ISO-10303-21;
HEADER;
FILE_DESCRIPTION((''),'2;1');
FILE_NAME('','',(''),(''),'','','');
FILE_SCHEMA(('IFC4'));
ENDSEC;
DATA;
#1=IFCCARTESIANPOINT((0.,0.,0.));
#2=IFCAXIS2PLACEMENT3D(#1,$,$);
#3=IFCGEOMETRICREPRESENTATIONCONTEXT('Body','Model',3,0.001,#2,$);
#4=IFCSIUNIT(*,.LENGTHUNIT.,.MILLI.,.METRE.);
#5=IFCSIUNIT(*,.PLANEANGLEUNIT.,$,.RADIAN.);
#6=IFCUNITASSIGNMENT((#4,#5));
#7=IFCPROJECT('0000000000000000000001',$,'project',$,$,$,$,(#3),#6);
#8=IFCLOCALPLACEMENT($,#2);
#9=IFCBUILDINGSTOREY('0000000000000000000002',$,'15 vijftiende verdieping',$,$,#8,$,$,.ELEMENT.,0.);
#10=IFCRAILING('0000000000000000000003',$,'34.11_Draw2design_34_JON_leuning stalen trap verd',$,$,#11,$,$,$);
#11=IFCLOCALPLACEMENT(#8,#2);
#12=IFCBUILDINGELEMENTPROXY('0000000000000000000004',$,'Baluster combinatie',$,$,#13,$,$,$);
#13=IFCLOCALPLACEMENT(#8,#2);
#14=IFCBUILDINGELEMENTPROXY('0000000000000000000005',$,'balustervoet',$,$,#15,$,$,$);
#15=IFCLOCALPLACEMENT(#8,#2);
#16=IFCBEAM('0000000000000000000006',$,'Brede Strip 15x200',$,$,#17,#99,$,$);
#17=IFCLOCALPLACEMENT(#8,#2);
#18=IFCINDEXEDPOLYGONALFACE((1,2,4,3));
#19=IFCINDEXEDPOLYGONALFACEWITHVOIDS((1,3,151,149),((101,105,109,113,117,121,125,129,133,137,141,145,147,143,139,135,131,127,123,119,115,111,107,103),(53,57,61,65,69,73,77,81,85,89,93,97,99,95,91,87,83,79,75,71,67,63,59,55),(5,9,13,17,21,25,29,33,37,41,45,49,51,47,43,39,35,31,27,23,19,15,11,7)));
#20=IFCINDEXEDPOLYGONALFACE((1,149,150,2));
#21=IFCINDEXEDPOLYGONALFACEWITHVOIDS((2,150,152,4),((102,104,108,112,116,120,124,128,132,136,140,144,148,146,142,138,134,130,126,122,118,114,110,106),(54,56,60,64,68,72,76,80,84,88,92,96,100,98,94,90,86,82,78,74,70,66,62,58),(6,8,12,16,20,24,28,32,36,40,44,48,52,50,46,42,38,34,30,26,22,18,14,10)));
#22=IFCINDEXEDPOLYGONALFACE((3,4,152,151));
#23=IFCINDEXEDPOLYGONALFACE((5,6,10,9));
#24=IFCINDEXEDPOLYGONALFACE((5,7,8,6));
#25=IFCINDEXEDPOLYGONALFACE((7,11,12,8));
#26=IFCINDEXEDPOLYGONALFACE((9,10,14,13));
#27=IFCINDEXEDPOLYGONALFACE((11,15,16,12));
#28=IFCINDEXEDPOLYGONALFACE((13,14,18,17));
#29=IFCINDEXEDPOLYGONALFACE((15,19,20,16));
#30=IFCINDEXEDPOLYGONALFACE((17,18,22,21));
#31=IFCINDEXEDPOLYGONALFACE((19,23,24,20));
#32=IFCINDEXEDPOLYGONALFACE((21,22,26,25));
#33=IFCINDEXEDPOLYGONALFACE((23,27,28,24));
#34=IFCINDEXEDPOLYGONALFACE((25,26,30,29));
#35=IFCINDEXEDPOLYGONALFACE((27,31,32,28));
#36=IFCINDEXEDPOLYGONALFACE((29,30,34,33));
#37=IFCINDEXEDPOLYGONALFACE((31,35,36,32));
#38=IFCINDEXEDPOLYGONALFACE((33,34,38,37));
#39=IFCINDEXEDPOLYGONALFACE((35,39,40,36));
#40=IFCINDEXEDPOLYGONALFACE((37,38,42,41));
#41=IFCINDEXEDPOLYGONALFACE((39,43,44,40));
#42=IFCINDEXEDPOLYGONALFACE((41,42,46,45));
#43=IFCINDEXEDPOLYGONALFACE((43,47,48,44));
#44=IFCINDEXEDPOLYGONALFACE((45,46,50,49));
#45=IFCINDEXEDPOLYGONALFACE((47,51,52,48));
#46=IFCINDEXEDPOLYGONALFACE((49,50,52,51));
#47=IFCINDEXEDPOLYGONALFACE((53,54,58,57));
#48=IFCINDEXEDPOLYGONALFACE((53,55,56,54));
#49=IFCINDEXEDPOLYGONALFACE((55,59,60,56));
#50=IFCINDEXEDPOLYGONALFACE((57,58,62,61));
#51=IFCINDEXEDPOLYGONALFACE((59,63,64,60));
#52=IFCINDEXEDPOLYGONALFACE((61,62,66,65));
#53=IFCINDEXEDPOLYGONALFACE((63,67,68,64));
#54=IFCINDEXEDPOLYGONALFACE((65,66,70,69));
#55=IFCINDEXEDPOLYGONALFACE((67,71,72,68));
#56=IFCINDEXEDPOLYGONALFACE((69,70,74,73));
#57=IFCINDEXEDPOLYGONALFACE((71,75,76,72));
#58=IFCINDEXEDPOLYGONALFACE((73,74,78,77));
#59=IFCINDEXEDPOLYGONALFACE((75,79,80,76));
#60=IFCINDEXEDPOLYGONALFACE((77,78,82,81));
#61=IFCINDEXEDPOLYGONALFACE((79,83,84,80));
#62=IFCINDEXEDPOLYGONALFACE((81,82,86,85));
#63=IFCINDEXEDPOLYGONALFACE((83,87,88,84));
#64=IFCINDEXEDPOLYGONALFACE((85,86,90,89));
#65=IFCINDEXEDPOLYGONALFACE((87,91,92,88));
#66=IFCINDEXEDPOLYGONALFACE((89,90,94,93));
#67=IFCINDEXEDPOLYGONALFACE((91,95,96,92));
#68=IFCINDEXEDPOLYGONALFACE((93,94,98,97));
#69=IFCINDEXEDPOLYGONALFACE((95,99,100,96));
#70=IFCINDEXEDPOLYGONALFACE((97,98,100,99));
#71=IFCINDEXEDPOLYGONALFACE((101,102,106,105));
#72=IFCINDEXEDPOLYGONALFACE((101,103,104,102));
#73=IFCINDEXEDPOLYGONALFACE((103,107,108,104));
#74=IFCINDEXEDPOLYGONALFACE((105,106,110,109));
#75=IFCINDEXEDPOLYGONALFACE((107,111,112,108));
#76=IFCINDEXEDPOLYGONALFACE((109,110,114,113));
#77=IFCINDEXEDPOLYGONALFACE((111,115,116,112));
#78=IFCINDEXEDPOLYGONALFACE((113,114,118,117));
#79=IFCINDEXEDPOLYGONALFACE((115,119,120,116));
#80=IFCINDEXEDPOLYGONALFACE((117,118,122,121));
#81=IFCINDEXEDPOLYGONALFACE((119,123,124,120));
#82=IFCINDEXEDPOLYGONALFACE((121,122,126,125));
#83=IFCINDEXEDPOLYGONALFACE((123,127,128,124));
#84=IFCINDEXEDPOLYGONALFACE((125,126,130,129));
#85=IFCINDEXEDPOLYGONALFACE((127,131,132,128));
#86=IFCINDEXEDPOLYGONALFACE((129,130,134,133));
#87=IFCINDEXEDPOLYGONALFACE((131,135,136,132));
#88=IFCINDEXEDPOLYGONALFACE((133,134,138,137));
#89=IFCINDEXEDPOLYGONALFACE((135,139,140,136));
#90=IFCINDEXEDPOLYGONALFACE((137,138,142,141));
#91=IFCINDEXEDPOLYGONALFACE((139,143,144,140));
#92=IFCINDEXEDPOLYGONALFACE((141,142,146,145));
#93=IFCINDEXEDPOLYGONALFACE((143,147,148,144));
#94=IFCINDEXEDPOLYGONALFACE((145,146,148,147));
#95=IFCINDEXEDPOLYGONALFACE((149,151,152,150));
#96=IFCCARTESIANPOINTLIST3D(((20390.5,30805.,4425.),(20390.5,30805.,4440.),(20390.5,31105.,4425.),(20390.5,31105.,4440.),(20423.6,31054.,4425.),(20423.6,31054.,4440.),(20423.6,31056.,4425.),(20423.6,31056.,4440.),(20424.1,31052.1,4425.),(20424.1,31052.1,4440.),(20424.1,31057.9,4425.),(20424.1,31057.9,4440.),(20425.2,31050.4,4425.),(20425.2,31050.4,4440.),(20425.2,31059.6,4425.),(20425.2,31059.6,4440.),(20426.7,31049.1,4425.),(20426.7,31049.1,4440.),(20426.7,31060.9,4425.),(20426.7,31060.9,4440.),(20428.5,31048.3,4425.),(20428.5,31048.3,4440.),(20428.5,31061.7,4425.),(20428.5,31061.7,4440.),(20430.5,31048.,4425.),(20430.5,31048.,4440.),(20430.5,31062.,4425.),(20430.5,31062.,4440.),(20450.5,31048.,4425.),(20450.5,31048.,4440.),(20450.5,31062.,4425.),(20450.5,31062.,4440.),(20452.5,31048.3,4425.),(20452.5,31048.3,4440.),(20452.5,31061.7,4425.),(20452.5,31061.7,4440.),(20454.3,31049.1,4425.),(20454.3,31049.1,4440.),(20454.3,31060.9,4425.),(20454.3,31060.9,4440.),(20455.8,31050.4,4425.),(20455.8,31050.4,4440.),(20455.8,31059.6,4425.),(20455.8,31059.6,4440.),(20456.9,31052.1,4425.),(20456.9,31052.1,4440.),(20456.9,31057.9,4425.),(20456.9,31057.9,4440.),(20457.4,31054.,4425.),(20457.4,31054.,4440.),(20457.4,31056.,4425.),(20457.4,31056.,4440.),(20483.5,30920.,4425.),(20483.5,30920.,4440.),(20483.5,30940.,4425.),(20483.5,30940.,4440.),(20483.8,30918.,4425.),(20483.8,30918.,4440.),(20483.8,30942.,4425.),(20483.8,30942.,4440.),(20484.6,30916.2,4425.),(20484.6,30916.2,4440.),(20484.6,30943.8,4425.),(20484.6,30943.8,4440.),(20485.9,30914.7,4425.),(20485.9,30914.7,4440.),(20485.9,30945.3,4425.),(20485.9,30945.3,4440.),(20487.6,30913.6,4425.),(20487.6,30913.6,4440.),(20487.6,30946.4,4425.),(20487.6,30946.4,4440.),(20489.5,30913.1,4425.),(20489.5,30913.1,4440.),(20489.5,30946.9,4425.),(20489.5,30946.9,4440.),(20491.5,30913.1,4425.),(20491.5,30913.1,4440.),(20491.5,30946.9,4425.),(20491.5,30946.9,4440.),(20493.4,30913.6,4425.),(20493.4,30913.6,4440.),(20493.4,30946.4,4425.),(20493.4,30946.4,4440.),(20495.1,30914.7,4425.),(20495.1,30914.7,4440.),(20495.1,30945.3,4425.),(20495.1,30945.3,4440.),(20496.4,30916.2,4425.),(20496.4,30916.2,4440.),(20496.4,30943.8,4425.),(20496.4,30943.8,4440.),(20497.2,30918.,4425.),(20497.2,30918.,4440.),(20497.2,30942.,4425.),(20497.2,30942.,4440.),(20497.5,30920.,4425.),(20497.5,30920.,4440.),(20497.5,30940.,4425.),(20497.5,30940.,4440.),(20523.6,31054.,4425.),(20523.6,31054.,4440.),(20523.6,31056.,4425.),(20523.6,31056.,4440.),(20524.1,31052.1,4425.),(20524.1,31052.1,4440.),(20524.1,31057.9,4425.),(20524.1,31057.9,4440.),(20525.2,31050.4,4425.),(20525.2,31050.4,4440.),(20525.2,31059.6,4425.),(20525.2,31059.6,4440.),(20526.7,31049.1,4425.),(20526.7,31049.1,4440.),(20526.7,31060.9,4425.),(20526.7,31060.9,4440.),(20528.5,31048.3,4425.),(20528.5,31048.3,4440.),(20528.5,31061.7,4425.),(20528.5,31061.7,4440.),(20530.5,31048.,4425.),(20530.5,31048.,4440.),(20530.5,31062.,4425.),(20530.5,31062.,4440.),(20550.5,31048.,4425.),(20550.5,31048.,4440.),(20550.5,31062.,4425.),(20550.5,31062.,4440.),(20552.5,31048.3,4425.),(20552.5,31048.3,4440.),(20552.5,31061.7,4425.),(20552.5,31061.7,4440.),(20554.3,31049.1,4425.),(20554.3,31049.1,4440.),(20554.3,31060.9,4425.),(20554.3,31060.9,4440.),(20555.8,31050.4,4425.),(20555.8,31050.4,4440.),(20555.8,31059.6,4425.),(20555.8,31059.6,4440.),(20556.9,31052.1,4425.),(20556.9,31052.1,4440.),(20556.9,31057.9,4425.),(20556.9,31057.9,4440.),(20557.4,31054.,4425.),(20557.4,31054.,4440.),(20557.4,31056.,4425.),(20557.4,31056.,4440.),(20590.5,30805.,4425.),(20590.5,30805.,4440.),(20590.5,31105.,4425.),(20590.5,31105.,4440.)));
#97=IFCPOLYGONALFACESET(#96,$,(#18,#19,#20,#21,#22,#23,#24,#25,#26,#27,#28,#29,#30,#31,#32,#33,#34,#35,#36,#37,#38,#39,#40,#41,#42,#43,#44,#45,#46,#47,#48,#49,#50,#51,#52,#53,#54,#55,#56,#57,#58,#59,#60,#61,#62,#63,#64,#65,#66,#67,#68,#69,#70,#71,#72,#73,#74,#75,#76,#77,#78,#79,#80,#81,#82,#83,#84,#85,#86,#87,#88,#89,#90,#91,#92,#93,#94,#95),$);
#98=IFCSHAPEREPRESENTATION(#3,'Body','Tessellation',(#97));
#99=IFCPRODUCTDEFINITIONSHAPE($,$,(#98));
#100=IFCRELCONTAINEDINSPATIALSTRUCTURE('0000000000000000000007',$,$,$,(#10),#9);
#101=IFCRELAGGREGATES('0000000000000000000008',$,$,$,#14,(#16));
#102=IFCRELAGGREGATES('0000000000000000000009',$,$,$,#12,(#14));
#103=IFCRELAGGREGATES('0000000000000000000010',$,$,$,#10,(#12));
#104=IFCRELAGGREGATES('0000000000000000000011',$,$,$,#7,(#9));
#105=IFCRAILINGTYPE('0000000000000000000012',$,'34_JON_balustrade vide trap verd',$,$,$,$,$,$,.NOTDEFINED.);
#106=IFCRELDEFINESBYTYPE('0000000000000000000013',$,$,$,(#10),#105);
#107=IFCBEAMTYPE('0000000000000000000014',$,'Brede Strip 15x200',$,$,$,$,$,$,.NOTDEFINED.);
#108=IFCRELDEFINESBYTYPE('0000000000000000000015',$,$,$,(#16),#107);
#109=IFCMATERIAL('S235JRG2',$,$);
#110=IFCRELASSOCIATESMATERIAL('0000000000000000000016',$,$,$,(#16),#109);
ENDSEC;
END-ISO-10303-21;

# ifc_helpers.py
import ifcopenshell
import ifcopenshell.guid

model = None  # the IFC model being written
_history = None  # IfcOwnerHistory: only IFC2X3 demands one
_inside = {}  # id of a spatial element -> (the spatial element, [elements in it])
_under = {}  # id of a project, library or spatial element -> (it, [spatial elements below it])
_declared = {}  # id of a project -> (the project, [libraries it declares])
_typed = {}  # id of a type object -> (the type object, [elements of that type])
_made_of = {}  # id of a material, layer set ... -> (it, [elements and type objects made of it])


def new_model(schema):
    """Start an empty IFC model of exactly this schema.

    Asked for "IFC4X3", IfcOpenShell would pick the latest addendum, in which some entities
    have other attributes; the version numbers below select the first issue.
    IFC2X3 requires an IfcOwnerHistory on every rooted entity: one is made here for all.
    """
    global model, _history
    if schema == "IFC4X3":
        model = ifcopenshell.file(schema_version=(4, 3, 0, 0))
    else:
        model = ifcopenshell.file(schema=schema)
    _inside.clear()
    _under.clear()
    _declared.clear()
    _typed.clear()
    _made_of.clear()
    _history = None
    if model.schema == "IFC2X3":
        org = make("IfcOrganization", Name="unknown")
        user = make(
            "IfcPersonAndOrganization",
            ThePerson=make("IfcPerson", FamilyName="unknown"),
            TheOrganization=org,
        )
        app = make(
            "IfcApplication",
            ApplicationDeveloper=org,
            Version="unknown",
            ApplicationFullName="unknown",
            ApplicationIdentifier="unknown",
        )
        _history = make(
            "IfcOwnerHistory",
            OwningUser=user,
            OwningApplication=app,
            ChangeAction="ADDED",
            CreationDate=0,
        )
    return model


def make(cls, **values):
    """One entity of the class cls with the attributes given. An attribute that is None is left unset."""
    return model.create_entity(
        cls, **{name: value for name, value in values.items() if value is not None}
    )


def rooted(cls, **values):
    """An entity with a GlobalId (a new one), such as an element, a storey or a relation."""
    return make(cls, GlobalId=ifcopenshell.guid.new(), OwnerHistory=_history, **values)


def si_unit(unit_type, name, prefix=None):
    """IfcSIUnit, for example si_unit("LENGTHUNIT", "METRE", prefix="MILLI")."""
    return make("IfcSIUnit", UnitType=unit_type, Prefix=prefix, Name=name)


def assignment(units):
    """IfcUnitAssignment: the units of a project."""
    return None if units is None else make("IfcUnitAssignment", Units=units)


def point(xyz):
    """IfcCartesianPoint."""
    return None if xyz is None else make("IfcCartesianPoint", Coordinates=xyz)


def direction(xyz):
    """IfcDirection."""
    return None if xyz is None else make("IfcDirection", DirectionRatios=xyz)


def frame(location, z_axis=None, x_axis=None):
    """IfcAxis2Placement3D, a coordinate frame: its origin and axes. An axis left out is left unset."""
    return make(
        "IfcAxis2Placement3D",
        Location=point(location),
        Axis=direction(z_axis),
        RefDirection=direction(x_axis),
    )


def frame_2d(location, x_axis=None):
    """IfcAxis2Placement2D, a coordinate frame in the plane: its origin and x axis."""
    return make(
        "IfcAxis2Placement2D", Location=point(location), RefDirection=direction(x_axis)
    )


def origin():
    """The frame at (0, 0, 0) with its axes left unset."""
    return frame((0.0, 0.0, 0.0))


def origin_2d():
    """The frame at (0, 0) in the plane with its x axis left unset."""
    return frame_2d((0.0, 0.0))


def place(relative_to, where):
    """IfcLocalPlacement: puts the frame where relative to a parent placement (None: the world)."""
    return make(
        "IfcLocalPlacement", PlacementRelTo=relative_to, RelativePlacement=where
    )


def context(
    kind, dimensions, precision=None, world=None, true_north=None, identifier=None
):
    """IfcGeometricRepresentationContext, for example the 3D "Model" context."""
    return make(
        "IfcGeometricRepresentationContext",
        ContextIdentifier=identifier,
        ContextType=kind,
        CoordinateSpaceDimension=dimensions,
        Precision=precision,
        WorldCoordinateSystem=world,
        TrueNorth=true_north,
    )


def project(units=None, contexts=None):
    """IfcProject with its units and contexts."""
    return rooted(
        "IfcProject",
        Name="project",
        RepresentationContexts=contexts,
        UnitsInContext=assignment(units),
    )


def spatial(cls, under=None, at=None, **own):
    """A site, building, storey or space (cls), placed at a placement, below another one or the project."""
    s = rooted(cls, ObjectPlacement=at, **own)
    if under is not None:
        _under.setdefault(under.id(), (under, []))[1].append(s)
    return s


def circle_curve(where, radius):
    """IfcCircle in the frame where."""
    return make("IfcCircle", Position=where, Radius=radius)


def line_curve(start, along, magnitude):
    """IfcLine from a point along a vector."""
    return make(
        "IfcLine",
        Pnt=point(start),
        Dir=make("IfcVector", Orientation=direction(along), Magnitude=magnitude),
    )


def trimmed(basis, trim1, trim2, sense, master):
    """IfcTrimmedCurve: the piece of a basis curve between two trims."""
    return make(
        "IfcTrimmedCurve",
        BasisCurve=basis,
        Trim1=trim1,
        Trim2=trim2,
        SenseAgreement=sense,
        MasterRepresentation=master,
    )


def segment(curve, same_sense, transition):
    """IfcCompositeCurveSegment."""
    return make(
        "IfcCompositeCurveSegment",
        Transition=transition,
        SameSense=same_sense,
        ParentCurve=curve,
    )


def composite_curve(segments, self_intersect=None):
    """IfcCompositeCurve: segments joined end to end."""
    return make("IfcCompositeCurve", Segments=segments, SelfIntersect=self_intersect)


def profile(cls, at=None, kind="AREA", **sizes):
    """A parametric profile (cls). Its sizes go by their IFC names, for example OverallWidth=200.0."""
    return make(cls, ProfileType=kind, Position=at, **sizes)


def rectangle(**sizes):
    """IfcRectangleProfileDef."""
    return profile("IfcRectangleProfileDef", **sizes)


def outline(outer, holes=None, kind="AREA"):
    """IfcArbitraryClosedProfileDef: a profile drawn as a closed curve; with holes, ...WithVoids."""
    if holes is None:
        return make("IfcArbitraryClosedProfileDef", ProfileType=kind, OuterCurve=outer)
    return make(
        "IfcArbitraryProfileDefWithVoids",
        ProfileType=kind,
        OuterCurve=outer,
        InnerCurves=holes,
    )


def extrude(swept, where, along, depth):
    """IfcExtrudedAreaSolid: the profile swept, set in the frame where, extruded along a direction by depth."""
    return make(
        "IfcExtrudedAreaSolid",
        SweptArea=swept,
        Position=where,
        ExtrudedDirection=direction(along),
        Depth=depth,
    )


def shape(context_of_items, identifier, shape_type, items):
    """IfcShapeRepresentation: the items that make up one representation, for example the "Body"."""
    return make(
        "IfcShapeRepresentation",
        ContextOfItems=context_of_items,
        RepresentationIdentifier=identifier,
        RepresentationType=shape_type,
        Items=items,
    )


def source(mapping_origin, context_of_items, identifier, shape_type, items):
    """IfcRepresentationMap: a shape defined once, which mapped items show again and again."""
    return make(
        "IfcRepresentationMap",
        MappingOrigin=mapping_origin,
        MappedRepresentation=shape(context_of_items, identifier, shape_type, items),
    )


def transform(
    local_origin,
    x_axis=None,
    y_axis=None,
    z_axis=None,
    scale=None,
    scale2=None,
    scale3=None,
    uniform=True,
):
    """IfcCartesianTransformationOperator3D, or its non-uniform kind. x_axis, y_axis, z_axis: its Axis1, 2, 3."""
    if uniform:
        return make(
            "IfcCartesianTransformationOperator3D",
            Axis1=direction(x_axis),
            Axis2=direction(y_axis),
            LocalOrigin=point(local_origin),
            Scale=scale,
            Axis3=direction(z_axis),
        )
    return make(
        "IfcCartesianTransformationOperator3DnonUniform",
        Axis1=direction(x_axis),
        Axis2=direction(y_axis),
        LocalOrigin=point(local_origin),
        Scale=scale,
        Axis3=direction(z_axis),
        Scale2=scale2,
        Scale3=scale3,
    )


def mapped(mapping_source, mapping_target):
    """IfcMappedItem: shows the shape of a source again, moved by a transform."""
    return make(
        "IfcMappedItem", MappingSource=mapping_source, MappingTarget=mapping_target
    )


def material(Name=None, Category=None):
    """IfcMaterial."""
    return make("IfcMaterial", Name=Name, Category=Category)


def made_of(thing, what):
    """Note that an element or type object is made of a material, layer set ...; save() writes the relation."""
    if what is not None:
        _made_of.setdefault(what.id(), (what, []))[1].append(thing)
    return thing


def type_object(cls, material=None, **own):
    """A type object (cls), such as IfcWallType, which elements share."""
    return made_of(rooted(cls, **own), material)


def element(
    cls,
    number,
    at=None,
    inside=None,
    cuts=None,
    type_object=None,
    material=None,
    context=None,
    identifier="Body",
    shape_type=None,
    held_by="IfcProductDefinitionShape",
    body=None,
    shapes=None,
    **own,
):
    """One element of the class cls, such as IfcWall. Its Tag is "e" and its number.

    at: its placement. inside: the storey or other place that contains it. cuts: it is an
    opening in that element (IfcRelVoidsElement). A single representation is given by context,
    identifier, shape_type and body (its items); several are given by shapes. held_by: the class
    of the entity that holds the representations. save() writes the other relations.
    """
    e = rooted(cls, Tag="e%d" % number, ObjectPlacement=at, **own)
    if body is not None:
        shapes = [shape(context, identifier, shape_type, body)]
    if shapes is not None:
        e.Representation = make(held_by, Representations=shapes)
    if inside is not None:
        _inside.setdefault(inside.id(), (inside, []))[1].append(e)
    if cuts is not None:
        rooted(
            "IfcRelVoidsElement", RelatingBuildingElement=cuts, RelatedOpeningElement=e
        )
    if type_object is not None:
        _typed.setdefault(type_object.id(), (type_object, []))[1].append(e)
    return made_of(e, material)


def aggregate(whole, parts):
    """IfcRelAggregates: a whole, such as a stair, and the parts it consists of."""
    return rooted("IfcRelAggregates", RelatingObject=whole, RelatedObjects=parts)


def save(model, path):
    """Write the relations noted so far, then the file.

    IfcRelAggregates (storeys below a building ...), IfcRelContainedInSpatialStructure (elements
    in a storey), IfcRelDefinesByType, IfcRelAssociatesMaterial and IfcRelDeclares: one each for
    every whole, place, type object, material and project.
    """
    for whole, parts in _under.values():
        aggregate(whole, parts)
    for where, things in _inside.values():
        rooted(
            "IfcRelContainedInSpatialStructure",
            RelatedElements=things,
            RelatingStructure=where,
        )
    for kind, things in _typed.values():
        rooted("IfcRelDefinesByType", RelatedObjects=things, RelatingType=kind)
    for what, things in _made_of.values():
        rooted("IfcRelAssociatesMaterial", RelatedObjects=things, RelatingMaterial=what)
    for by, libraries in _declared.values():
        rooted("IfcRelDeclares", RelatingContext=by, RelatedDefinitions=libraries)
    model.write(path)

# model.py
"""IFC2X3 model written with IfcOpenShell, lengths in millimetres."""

from ifc_helpers import new_model, si_unit, point, frame, frame_2d, origin, origin_2d, place, context, project, spatial, circle_curve, line_curve, trimmed, segment, composite_curve, rectangle, outline, extrude, source, transform, mapped, material, type_object, element, aggregate, save


model = new_model("IFC2X3")

# Units and contexts
model_context = context("Model", 3, precision=0.001, world=origin(), identifier="Body")
ifc_project = project(units=[si_unit("LENGTHUNIT", "METRE", prefix="MILLI"), si_unit("PLANEANGLEUNIT", "RADIAN")], contexts=[model_context])

# Storey
storey_placement = place(None, origin())
storey = spatial("IfcBuildingStorey", under=ifc_project, at=storey_placement, Name="15 vijftiende verdieping", CompositionType="ELEMENT", Elevation=0.0)

# Railing, building element proxies, beam, openings
railing_type = type_object("IfcRailingType", Name="34_JON_balustrade vide trap verd")
railing_placement = place(storey_placement, frame((-24393.0, 51609.5, -44800.0), z_axis=(0.0, 0.0, 1.0), x_axis=(0.0, -1.0, 0.0)))
railing = element("IfcRailing", 1, at=railing_placement, inside=storey, type_object=railing_type, Name="34.11_Draw2design_34_JON_leuning stalen trap verd")
proxy_1_placement = place(railing_placement, frame((20504.5, 45027.5, 49235.0), z_axis=(0.0, 0.0, 1.0), x_axis=(0.0, -1.0, 0.0)))
proxy_1 = element("IfcBuildingElementProxy", 2, at=proxy_1_placement, Name="Baluster combinatie")
proxy_2_placement = place(proxy_1_placement, frame((-44763.0, 21054.5, -49235.0), z_axis=(0.0, 0.0, 1.0), x_axis=(0.0, -1.0, 0.0)))
proxy_2 = element("IfcBuildingElementProxy", 3, at=proxy_2_placement, Name="balustervoet")
ifc_material_1 = material(Name="S235JRG2")
beam_type_1 = type_object("IfcBeamType", Name="Brede Strip 15x200")
shared_shape_1 = source(origin(), model_context, "Body", "SweptSolid", [
    extrude(rectangle(XDim=15.0, YDim=200.0, at=origin_2d()), origin(), (0.0, 0.0, -1.0), 300.0),
])
beam_1_placement = place(proxy_2_placement, frame((21054.5, 44907.0, 49232.5), z_axis=(1.0, 0.0, 0.0), x_axis=(0.0, 0.0, 1.0)))
beam_1 = element("IfcBeam", 4, at=beam_1_placement, type_object=beam_type_1, material=ifc_material_1, Name="Brede Strip 15x200", context=model_context, shape_type="MappedRepresentation", body=[
    mapped(shared_shape_1, transform((0.0, 0.0, 0.0), scale=1.0)),
])
opening_1_placement = place(beam_1_placement, frame((7.5, 0.0, -175.0), z_axis=(-1.0, 0.0, 0.0), x_axis=(0.0, 0.0, -1.0)))
element("IfcOpeningElement", 5, at=opening_1_placement, cuts=beam_1, ObjectType="Opening", context=model_context, shape_type="SweptSolid", body=[
    extrude(outline(composite_curve([segment(trimmed(circle_curve(frame_2d((10.0, 0.0), x_axis=(0.0, -1.0)), 7.0), [point((10.0, 7.0))], [point((10.0, -7.0))], False, "CARTESIAN"), True, "CONTINUOUS"), segment(trimmed(line_curve((10.0, -7.0), (-20.0, 0.0), 20.0), [point((10.0, -7.0))], [point((-10.0, -7.0))], True, "CARTESIAN"), True, "CONTINUOUS"), segment(trimmed(circle_curve(frame_2d((-10.0, 0.0), x_axis=(0.0, -1.0)), 7.0), [point((-10.0, -7.0))], [point((-10.0, 7.0))], False, "CARTESIAN"), True, "CONTINUOUS"), segment(trimmed(line_curve((-10.0, 7.0), (20.0, 0.0), 20.0), [point((-10.0, 7.0))], [point((10.0, 7.0))], True, "CARTESIAN"), True, "CONTINUOUS")], self_intersect=False)), origin(), (0.0, 0.0, 1.0), 15.0),
])
opening_2_placement = place(beam_1_placement, frame((7.5, -50.0, -50.0), z_axis=(-1.0, 0.0, 0.0), x_axis=(0.0, -1.0, 0.0)))
element("IfcOpeningElement", 6, at=opening_2_placement, cuts=beam_1, ObjectType="Opening", context=model_context, shape_type="SweptSolid", body=[
    extrude(outline(composite_curve([segment(trimmed(circle_curve(frame_2d((10.0, 0.0), x_axis=(0.0, -1.0)), 7.0), [point((10.0, 7.0))], [point((10.0, -7.0))], False, "CARTESIAN"), True, "CONTINUOUS"), segment(trimmed(line_curve((10.0, -7.0), (-20.0, 0.0), 20.0), [point((10.0, -7.0))], [point((-10.0, -7.0))], True, "CARTESIAN"), True, "CONTINUOUS"), segment(trimmed(circle_curve(frame_2d((-10.0, 0.0), x_axis=(0.0, -1.0)), 7.0), [point((-10.0, -7.0))], [point((-10.0, 7.0))], False, "CARTESIAN"), True, "CONTINUOUS"), segment(trimmed(line_curve((-10.0, 7.0), (20.0, 0.0), 20.0), [point((-10.0, 7.0))], [point((10.0, 7.0))], True, "CARTESIAN"), True, "CONTINUOUS")], self_intersect=False)), origin(), (0.0, 0.0, 1.0), 15.0),
])
opening_3_placement = place(beam_1_placement, frame((7.5, 50.0, -50.0), z_axis=(-1.0, 0.0, 0.0), x_axis=(0.0, -1.0, 0.0)))
element("IfcOpeningElement", 7, at=opening_3_placement, cuts=beam_1, ObjectType="Opening", context=model_context, shape_type="SweptSolid", body=[
    extrude(outline(composite_curve([segment(trimmed(circle_curve(frame_2d((10.0, 0.0), x_axis=(0.0, -1.0)), 7.0), [point((10.0, 7.0))], [point((10.0, -7.0))], False, "CARTESIAN"), True, "CONTINUOUS"), segment(trimmed(line_curve((10.0, -7.0), (-20.0, 0.0), 20.0), [point((10.0, -7.0))], [point((-10.0, -7.0))], True, "CARTESIAN"), True, "CONTINUOUS"), segment(trimmed(circle_curve(frame_2d((-10.0, 0.0), x_axis=(0.0, -1.0)), 7.0), [point((-10.0, -7.0))], [point((-10.0, 7.0))], False, "CARTESIAN"), True, "CONTINUOUS"), segment(trimmed(line_curve((-10.0, 7.0), (20.0, 0.0), 20.0), [point((-10.0, 7.0))], [point((10.0, 7.0))], True, "CARTESIAN"), True, "CONTINUOUS")], self_intersect=False)), origin(), (0.0, 0.0, 1.0), 15.0),
])
aggregate(proxy_2, [beam_1])
aggregate(proxy_1, [proxy_2])
aggregate(railing, [proxy_1])

save(model, "model.ifc")
